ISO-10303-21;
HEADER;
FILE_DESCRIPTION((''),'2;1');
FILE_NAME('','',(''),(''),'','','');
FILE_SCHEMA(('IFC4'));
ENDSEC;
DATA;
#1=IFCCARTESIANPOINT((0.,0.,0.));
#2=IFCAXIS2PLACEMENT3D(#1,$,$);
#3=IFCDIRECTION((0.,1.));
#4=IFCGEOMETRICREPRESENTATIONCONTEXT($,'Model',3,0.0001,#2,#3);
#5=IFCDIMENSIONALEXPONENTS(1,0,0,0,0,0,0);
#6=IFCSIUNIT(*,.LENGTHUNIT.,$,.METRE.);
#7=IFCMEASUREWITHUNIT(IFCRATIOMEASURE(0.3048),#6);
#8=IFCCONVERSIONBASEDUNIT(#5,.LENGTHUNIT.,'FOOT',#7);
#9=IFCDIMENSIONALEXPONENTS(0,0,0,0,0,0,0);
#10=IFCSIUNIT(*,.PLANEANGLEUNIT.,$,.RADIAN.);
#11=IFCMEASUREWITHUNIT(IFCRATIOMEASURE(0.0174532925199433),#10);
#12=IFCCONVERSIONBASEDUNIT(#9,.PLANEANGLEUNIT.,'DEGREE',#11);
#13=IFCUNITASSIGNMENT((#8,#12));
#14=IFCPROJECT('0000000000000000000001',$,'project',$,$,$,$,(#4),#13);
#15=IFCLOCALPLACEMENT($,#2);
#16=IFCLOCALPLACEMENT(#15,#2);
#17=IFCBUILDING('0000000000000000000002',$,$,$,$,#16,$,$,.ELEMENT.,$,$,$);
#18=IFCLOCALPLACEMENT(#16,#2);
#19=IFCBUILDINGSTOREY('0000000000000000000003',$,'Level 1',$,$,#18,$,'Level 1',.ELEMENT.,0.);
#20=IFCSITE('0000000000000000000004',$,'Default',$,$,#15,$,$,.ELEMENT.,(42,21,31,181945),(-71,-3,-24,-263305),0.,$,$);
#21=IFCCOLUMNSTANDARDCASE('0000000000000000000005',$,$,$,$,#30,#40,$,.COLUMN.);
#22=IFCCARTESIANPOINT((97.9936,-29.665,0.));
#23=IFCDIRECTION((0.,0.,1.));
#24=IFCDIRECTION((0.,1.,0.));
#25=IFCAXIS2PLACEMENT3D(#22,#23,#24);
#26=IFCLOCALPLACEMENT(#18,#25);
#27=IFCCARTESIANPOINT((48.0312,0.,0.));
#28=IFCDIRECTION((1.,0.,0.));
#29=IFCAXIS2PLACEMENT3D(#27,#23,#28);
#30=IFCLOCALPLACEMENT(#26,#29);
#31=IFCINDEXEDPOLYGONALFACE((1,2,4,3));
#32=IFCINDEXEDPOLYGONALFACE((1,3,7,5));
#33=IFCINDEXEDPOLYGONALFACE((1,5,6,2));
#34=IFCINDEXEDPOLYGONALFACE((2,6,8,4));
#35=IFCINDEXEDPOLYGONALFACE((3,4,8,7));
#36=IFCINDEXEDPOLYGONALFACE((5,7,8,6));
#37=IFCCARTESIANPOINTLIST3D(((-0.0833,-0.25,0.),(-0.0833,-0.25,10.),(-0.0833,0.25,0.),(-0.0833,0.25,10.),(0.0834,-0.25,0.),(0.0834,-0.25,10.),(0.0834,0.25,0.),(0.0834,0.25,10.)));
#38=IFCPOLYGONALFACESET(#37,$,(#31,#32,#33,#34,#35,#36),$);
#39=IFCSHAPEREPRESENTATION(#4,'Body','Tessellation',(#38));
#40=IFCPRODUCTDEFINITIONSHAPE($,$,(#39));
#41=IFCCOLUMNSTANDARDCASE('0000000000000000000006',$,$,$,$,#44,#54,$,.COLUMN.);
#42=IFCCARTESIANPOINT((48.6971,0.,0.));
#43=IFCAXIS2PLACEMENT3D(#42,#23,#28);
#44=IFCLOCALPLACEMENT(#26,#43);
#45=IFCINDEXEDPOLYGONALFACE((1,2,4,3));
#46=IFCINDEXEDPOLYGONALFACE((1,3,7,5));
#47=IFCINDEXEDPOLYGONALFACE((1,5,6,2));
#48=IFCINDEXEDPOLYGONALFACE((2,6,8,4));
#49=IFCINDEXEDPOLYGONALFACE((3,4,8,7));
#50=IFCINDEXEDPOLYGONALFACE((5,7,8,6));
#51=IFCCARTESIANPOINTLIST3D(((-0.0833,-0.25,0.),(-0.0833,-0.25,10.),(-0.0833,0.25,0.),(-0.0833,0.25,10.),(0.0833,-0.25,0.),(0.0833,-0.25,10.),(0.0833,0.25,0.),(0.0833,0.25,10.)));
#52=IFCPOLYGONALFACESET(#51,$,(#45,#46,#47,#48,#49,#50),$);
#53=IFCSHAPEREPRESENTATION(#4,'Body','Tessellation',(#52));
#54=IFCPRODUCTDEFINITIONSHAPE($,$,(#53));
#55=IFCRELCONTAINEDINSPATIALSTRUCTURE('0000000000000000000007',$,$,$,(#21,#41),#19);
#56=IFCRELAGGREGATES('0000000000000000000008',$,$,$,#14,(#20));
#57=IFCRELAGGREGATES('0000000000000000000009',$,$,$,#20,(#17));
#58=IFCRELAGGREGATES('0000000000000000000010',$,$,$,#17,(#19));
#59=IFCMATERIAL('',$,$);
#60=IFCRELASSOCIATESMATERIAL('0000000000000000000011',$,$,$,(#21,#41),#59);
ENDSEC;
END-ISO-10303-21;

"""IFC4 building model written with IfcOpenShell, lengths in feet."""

from ifc_helpers import new_model, entity, si_unit, converted_unit, direction, frame, origin, place, context, project, spatial, rectangle, extrude, material, element, save


model = new_model("IFC4")

# Units and contexts
model_context = context("Model", 3, precision=0.0001, world=origin(), true_north=direction((0.0, 1.0)))
ifc_project = project(units=[converted_unit("LENGTHUNIT", "FOOT", entity("IfcRatioMeasure", 0.3048), si_unit("LENGTHUNIT", "METRE"), dimensions=[1, 0, 0, 0, 0, 0, 0]), converted_unit("PLANEANGLEUNIT", "DEGREE", entity("IfcRatioMeasure", 0.0174532925199433), si_unit("PLANEANGLEUNIT", "RADIAN"), dimensions=[0, 0, 0, 0, 0, 0, 0])], contexts=[model_context])

# Site, building, storey
site_placement = place(None, origin())
site = spatial("IfcSite", under=ifc_project, at=site_placement, Name="Default", CompositionType="ELEMENT", RefLatitude=(42, 21, 31, 181945), RefLongitude=(-71, -3, -24, -263305), RefElevation=0.0)
building_placement = place(site_placement, origin())
building = spatial("IfcBuilding", under=site, at=building_placement, CompositionType="ELEMENT")
storey_placement = place(building_placement, origin())
storey = spatial("IfcBuildingStorey", under=building, at=storey_placement, Name="Level 1", LongName="Level 1", CompositionType="ELEMENT", Elevation=0.0)

# Columns
ifc_material_1 = material(Name="")
placement = place(storey_placement, frame((97.9936, -29.665, 0.0), z_axis=(0.0, 0.0, 1.0), x_axis=(0.0, 1.0, 0.0)))
for number, where, z_axis, x_axis in (
    (1, (48.0312, 0.0, 0.0), (0.0, 0.0, 1.0), (1.0, 0.0, 0.0)),
    (2, (48.6971, 0.0, 0.0), (0.0, 0.0, 1.0), (1.0, 0.0, 0.0)),
):
    element("IfcColumnStandardCase", number, at=place(placement, frame(where, z_axis=z_axis, x_axis=x_axis)), inside=storey, material=ifc_material_1, PredefinedType="COLUMN", context=model_context, shape_type="SweptSolid", body=[
        extrude(rectangle(XDim=0.1667, YDim=0.5), origin(), (0.0, 0.0, 1.0), 10.0),
    ])

save(model, "model.ifc")
